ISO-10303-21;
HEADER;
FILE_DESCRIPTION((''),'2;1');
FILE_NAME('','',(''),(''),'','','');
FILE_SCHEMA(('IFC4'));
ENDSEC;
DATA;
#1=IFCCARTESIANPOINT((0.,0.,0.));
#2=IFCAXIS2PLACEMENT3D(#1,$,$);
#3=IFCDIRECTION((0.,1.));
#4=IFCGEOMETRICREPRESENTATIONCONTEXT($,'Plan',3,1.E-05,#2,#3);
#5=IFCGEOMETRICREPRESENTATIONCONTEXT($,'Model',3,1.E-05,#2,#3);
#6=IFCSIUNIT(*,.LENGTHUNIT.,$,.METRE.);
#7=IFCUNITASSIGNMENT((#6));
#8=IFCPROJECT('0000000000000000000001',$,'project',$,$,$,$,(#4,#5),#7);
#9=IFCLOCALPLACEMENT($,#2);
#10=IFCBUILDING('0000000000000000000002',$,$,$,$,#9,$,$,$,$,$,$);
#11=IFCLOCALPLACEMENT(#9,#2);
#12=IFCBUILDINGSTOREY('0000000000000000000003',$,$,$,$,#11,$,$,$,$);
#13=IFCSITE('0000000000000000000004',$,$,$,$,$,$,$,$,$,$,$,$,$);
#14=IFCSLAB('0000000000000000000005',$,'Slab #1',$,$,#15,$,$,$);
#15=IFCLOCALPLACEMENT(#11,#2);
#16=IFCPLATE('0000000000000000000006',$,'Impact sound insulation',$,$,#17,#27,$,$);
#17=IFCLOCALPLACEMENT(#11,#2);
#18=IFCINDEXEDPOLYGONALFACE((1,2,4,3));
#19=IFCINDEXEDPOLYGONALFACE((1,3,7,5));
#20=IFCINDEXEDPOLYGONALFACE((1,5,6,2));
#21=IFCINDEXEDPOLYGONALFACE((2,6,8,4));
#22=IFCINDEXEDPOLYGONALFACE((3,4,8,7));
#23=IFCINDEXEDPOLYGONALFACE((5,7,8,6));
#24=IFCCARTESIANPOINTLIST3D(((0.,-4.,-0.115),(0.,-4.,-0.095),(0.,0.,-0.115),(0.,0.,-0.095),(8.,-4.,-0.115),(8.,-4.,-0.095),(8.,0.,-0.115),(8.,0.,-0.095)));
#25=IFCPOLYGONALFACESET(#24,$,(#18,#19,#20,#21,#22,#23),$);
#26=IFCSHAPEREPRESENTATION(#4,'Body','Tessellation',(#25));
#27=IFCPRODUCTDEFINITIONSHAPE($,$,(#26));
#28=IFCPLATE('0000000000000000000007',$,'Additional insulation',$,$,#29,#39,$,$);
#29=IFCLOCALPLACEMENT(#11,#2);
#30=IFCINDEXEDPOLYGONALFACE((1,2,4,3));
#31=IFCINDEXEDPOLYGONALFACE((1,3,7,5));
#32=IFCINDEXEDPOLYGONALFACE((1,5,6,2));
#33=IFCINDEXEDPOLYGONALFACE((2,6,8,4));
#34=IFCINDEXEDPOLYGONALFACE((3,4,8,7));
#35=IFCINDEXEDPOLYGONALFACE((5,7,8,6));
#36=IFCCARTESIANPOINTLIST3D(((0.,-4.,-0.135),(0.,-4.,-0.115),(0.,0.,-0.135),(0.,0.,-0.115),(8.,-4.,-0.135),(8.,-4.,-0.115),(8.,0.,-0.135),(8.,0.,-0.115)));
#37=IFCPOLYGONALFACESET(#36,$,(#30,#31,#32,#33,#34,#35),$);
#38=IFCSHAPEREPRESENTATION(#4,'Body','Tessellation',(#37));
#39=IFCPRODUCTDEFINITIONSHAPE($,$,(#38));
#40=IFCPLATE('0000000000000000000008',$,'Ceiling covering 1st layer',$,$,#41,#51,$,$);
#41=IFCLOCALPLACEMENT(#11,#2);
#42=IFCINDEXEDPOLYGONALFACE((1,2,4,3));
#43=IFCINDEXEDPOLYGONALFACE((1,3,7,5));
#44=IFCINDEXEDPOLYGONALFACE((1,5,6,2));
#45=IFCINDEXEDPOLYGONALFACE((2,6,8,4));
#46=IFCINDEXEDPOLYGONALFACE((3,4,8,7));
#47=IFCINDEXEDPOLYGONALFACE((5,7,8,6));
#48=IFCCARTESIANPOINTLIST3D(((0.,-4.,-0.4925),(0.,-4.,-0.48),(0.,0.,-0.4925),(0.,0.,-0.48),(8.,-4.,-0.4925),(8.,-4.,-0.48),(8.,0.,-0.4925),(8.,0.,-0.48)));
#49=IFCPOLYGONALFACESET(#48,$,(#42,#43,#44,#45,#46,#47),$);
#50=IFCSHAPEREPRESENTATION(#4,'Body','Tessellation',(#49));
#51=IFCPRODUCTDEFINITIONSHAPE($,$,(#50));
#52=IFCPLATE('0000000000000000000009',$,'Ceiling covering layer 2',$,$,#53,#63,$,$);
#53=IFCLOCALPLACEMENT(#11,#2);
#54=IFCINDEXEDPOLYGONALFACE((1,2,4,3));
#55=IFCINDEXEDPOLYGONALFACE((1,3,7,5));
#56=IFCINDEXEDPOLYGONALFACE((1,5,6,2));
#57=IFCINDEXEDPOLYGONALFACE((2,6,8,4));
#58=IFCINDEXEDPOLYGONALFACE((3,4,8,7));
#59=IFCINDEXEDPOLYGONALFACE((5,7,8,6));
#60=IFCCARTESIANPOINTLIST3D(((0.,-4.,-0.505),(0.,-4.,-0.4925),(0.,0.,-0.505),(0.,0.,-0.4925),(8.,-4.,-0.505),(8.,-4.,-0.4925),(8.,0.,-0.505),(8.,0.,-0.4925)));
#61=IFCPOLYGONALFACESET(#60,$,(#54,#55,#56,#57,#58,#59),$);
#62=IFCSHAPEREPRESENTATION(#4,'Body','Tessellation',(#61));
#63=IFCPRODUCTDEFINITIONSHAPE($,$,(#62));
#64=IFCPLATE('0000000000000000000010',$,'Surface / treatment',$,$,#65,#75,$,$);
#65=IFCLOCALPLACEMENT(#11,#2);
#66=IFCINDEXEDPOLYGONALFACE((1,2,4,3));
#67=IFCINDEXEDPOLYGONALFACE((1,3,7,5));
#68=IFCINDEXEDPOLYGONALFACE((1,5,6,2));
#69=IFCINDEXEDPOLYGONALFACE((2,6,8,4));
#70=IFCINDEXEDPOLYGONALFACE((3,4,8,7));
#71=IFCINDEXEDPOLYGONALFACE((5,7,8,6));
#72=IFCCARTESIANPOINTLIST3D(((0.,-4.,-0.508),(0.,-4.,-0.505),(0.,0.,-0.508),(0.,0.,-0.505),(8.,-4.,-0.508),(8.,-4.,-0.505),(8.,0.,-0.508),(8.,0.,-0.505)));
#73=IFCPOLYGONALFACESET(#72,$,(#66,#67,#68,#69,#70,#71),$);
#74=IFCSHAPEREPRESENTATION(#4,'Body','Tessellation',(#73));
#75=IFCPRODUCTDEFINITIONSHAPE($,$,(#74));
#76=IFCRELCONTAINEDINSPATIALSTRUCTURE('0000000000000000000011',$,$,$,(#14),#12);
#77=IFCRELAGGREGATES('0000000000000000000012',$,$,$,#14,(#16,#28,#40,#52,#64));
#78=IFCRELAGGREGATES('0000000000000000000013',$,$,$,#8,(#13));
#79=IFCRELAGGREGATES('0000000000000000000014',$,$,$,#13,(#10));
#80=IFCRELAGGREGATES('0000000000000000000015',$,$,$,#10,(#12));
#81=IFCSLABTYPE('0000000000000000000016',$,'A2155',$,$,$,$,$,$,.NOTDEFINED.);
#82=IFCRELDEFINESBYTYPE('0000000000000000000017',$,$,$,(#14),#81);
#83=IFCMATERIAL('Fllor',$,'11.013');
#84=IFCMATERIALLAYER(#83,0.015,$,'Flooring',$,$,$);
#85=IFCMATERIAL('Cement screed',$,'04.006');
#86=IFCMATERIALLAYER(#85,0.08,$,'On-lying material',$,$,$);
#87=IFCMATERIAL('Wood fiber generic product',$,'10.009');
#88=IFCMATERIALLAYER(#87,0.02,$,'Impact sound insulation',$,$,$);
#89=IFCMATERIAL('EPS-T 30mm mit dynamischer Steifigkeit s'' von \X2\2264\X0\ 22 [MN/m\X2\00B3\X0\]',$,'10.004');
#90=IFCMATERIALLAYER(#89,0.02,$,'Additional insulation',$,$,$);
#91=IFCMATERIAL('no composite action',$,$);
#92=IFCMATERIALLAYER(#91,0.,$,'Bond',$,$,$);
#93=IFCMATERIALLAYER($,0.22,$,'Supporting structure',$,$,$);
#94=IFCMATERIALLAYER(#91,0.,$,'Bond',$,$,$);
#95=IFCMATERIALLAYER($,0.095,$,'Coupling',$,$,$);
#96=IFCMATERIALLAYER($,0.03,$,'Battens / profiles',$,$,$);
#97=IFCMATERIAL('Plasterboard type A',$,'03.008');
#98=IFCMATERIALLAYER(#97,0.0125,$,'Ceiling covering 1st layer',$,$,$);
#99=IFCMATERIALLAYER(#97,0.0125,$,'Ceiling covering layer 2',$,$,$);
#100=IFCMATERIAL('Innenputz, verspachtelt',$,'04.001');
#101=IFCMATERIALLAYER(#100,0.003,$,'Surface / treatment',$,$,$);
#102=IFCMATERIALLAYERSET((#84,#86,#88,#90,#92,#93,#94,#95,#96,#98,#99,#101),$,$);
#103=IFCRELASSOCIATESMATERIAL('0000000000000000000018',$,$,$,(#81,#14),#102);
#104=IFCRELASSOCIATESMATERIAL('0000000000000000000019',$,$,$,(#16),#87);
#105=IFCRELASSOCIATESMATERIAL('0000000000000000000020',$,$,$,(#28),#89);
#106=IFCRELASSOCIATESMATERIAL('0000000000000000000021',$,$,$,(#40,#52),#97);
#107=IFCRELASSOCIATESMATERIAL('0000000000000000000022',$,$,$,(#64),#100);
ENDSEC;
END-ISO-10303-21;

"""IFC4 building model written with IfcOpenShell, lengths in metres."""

from ifc_helpers import new_model, si_unit, direction, frame, frame_2d, origin, place, context, project, spatial, rectangle, extrude, material, layer, layer_set, type_object, element, aggregate, save


model = new_model("IFC4")

# Units and contexts
plan_context = context("Plan", 3, precision=1e-05, world=origin(), true_north=direction((0.0, 1.0)))
model_context = context("Model", 3, precision=1e-05, world=origin(), true_north=direction((0.0, 1.0)))
ifc_project = project(units=[si_unit("LENGTHUNIT", "METRE")], contexts=[plan_context, model_context])

# Site, building, storey
site = spatial("IfcSite", under=ifc_project)
building_placement = place(None, origin())
building = spatial("IfcBuilding", under=site, at=building_placement)
storey_placement = place(building_placement, origin())
storey = spatial("IfcBuildingStorey", under=building, at=storey_placement)

# Slab, plates
ifc_material_1 = material(Name="Fllor", Category="11.013")
ifc_layer_1 = layer(ifc_material_1, 0.015, Name="Flooring")
ifc_material_2 = material(Name="Cement screed", Category="04.006")
ifc_layer_2 = layer(ifc_material_2, 0.08, Name="On-lying material")
ifc_material_3 = material(Name="Wood fiber generic product", Category="10.009")
ifc_layer_3 = layer(ifc_material_3, 0.02, Name="Impact sound insulation")
ifc_material_4 = material(Name="EPS-T 30mm mit dynamischer Steifigkeit s' von ≤ 22 [MN/m³]", Category="10.004")
ifc_layer_4 = layer(ifc_material_4, 0.02, Name="Additional insulation")
ifc_material_5 = material(Name="no composite action")
ifc_layer_5 = layer(ifc_material_5, 0.0, Name="Bond")
ifc_layer_6 = layer(None, 0.22, Name="Supporting structure")
ifc_layer_7 = layer(ifc_material_5, 0.0, Name="Bond")
ifc_layer_8 = layer(None, 0.095, Name="Coupling")
ifc_layer_9 = layer(None, 0.03, Name="Battens / profiles")
ifc_material_6 = material(Name="Plasterboard type A", Category="03.008")
ifc_layer_10 = layer(ifc_material_6, 0.0125, Name="Ceiling covering 1st layer")
ifc_layer_11 = layer(ifc_material_6, 0.0125, Name="Ceiling covering layer 2")
ifc_material_7 = material(Name="Innenputz, verspachtelt", Category="04.001")
ifc_layer_12 = layer(ifc_material_7, 0.003, Name="Surface / treatment")
ifc_layer_set = layer_set([ifc_layer_1, ifc_layer_2, ifc_layer_3, ifc_layer_4, ifc_layer_5, ifc_layer_6, ifc_layer_7, ifc_layer_8, ifc_layer_9, ifc_layer_10, ifc_layer_11, ifc_layer_12])
slab_type = type_object("IfcSlabType", Name="A2155", PredefinedType="NOTDEFINED", material=ifc_layer_set)
slab_placement = place(None, frame((0.0, 0.0, 0.0), z_axis=(0.0, 0.0, -1.0), x_axis=(1.0, 0.0, 0.0)))
slab = element("IfcSlab", 1, at=slab_placement, inside=storey, type_object=slab_type, material=ifc_layer_set, Name="Slab #1")
plate_1_placement = place(slab_placement, origin())
plate_1 = element("IfcPlate", 2, at=plate_1_placement, material=ifc_material_3, Name="Impact sound insulation", context=plan_context, shape_type="SweptSolid", body=[
    extrude(rectangle(XDim=8.0, YDim=4.0, at=frame_2d((4.0, 2.0), x_axis=(1.0, 0.0))), frame((0.0, 0.0, 0.095), z_axis=(0.0, 0.0, 1.0), x_axis=(1.0, 0.0, 0.0)), (0.0, 0.0, 1.0), 0.02),
])
plate_2_placement = place(slab_placement, origin())
plate_2 = element("IfcPlate", 3, at=plate_2_placement, material=ifc_material_4, Name="Additional insulation", context=plan_context, shape_type="SweptSolid", body=[
    extrude(rectangle(XDim=8.0, YDim=4.0, at=frame_2d((4.0, 2.0), x_axis=(1.0, 0.0))), frame((0.0, 0.0, 0.115), z_axis=(0.0, 0.0, 1.0), x_axis=(1.0, 0.0, 0.0)), (0.0, 0.0, 1.0), 0.02),
])
plate_3_placement = place(slab_placement, origin())
plate_3 = element("IfcPlate", 4, at=plate_3_placement, material=ifc_material_6, Name="Ceiling covering 1st layer", context=plan_context, shape_type="SweptSolid", body=[
    extrude(rectangle(XDim=8.0, YDim=4.0, at=frame_2d((4.0, 2.0), x_axis=(1.0, 0.0))), frame((0.0, 0.0, 0.48), z_axis=(0.0, 0.0, 1.0), x_axis=(1.0, 0.0, 0.0)), (0.0, 0.0, 1.0), 0.0125),
])
plate_4_placement = place(slab_placement, origin())
plate_4 = element("IfcPlate", 5, at=plate_4_placement, material=ifc_material_6, Name="Ceiling covering layer 2", context=plan_context, shape_type="SweptSolid", body=[
    extrude(rectangle(XDim=8.0, YDim=4.0, at=frame_2d((4.0, 2.0), x_axis=(1.0, 0.0))), frame((0.0, 0.0, 0.4925), z_axis=(0.0, 0.0, 1.0), x_axis=(1.0, 0.0, 0.0)), (0.0, 0.0, 1.0), 0.0125),
])
plate_5_placement = place(slab_placement, origin())
plate_5 = element("IfcPlate", 6, at=plate_5_placement, material=ifc_material_7, Name="Surface / treatment", context=plan_context, shape_type="SweptSolid", body=[
    extrude(rectangle(XDim=8.0, YDim=4.0, at=frame_2d((4.0, 2.0), x_axis=(1.0, 0.0))), frame((0.0, 0.0, 0.505), z_axis=(0.0, 0.0, 1.0), x_axis=(1.0, 0.0, 0.0)), (0.0, 0.0, 1.0), 0.003),
])
aggregate(slab, [plate_1, plate_2, plate_3, plate_4, plate_5])

save(model, "model.ifc")
